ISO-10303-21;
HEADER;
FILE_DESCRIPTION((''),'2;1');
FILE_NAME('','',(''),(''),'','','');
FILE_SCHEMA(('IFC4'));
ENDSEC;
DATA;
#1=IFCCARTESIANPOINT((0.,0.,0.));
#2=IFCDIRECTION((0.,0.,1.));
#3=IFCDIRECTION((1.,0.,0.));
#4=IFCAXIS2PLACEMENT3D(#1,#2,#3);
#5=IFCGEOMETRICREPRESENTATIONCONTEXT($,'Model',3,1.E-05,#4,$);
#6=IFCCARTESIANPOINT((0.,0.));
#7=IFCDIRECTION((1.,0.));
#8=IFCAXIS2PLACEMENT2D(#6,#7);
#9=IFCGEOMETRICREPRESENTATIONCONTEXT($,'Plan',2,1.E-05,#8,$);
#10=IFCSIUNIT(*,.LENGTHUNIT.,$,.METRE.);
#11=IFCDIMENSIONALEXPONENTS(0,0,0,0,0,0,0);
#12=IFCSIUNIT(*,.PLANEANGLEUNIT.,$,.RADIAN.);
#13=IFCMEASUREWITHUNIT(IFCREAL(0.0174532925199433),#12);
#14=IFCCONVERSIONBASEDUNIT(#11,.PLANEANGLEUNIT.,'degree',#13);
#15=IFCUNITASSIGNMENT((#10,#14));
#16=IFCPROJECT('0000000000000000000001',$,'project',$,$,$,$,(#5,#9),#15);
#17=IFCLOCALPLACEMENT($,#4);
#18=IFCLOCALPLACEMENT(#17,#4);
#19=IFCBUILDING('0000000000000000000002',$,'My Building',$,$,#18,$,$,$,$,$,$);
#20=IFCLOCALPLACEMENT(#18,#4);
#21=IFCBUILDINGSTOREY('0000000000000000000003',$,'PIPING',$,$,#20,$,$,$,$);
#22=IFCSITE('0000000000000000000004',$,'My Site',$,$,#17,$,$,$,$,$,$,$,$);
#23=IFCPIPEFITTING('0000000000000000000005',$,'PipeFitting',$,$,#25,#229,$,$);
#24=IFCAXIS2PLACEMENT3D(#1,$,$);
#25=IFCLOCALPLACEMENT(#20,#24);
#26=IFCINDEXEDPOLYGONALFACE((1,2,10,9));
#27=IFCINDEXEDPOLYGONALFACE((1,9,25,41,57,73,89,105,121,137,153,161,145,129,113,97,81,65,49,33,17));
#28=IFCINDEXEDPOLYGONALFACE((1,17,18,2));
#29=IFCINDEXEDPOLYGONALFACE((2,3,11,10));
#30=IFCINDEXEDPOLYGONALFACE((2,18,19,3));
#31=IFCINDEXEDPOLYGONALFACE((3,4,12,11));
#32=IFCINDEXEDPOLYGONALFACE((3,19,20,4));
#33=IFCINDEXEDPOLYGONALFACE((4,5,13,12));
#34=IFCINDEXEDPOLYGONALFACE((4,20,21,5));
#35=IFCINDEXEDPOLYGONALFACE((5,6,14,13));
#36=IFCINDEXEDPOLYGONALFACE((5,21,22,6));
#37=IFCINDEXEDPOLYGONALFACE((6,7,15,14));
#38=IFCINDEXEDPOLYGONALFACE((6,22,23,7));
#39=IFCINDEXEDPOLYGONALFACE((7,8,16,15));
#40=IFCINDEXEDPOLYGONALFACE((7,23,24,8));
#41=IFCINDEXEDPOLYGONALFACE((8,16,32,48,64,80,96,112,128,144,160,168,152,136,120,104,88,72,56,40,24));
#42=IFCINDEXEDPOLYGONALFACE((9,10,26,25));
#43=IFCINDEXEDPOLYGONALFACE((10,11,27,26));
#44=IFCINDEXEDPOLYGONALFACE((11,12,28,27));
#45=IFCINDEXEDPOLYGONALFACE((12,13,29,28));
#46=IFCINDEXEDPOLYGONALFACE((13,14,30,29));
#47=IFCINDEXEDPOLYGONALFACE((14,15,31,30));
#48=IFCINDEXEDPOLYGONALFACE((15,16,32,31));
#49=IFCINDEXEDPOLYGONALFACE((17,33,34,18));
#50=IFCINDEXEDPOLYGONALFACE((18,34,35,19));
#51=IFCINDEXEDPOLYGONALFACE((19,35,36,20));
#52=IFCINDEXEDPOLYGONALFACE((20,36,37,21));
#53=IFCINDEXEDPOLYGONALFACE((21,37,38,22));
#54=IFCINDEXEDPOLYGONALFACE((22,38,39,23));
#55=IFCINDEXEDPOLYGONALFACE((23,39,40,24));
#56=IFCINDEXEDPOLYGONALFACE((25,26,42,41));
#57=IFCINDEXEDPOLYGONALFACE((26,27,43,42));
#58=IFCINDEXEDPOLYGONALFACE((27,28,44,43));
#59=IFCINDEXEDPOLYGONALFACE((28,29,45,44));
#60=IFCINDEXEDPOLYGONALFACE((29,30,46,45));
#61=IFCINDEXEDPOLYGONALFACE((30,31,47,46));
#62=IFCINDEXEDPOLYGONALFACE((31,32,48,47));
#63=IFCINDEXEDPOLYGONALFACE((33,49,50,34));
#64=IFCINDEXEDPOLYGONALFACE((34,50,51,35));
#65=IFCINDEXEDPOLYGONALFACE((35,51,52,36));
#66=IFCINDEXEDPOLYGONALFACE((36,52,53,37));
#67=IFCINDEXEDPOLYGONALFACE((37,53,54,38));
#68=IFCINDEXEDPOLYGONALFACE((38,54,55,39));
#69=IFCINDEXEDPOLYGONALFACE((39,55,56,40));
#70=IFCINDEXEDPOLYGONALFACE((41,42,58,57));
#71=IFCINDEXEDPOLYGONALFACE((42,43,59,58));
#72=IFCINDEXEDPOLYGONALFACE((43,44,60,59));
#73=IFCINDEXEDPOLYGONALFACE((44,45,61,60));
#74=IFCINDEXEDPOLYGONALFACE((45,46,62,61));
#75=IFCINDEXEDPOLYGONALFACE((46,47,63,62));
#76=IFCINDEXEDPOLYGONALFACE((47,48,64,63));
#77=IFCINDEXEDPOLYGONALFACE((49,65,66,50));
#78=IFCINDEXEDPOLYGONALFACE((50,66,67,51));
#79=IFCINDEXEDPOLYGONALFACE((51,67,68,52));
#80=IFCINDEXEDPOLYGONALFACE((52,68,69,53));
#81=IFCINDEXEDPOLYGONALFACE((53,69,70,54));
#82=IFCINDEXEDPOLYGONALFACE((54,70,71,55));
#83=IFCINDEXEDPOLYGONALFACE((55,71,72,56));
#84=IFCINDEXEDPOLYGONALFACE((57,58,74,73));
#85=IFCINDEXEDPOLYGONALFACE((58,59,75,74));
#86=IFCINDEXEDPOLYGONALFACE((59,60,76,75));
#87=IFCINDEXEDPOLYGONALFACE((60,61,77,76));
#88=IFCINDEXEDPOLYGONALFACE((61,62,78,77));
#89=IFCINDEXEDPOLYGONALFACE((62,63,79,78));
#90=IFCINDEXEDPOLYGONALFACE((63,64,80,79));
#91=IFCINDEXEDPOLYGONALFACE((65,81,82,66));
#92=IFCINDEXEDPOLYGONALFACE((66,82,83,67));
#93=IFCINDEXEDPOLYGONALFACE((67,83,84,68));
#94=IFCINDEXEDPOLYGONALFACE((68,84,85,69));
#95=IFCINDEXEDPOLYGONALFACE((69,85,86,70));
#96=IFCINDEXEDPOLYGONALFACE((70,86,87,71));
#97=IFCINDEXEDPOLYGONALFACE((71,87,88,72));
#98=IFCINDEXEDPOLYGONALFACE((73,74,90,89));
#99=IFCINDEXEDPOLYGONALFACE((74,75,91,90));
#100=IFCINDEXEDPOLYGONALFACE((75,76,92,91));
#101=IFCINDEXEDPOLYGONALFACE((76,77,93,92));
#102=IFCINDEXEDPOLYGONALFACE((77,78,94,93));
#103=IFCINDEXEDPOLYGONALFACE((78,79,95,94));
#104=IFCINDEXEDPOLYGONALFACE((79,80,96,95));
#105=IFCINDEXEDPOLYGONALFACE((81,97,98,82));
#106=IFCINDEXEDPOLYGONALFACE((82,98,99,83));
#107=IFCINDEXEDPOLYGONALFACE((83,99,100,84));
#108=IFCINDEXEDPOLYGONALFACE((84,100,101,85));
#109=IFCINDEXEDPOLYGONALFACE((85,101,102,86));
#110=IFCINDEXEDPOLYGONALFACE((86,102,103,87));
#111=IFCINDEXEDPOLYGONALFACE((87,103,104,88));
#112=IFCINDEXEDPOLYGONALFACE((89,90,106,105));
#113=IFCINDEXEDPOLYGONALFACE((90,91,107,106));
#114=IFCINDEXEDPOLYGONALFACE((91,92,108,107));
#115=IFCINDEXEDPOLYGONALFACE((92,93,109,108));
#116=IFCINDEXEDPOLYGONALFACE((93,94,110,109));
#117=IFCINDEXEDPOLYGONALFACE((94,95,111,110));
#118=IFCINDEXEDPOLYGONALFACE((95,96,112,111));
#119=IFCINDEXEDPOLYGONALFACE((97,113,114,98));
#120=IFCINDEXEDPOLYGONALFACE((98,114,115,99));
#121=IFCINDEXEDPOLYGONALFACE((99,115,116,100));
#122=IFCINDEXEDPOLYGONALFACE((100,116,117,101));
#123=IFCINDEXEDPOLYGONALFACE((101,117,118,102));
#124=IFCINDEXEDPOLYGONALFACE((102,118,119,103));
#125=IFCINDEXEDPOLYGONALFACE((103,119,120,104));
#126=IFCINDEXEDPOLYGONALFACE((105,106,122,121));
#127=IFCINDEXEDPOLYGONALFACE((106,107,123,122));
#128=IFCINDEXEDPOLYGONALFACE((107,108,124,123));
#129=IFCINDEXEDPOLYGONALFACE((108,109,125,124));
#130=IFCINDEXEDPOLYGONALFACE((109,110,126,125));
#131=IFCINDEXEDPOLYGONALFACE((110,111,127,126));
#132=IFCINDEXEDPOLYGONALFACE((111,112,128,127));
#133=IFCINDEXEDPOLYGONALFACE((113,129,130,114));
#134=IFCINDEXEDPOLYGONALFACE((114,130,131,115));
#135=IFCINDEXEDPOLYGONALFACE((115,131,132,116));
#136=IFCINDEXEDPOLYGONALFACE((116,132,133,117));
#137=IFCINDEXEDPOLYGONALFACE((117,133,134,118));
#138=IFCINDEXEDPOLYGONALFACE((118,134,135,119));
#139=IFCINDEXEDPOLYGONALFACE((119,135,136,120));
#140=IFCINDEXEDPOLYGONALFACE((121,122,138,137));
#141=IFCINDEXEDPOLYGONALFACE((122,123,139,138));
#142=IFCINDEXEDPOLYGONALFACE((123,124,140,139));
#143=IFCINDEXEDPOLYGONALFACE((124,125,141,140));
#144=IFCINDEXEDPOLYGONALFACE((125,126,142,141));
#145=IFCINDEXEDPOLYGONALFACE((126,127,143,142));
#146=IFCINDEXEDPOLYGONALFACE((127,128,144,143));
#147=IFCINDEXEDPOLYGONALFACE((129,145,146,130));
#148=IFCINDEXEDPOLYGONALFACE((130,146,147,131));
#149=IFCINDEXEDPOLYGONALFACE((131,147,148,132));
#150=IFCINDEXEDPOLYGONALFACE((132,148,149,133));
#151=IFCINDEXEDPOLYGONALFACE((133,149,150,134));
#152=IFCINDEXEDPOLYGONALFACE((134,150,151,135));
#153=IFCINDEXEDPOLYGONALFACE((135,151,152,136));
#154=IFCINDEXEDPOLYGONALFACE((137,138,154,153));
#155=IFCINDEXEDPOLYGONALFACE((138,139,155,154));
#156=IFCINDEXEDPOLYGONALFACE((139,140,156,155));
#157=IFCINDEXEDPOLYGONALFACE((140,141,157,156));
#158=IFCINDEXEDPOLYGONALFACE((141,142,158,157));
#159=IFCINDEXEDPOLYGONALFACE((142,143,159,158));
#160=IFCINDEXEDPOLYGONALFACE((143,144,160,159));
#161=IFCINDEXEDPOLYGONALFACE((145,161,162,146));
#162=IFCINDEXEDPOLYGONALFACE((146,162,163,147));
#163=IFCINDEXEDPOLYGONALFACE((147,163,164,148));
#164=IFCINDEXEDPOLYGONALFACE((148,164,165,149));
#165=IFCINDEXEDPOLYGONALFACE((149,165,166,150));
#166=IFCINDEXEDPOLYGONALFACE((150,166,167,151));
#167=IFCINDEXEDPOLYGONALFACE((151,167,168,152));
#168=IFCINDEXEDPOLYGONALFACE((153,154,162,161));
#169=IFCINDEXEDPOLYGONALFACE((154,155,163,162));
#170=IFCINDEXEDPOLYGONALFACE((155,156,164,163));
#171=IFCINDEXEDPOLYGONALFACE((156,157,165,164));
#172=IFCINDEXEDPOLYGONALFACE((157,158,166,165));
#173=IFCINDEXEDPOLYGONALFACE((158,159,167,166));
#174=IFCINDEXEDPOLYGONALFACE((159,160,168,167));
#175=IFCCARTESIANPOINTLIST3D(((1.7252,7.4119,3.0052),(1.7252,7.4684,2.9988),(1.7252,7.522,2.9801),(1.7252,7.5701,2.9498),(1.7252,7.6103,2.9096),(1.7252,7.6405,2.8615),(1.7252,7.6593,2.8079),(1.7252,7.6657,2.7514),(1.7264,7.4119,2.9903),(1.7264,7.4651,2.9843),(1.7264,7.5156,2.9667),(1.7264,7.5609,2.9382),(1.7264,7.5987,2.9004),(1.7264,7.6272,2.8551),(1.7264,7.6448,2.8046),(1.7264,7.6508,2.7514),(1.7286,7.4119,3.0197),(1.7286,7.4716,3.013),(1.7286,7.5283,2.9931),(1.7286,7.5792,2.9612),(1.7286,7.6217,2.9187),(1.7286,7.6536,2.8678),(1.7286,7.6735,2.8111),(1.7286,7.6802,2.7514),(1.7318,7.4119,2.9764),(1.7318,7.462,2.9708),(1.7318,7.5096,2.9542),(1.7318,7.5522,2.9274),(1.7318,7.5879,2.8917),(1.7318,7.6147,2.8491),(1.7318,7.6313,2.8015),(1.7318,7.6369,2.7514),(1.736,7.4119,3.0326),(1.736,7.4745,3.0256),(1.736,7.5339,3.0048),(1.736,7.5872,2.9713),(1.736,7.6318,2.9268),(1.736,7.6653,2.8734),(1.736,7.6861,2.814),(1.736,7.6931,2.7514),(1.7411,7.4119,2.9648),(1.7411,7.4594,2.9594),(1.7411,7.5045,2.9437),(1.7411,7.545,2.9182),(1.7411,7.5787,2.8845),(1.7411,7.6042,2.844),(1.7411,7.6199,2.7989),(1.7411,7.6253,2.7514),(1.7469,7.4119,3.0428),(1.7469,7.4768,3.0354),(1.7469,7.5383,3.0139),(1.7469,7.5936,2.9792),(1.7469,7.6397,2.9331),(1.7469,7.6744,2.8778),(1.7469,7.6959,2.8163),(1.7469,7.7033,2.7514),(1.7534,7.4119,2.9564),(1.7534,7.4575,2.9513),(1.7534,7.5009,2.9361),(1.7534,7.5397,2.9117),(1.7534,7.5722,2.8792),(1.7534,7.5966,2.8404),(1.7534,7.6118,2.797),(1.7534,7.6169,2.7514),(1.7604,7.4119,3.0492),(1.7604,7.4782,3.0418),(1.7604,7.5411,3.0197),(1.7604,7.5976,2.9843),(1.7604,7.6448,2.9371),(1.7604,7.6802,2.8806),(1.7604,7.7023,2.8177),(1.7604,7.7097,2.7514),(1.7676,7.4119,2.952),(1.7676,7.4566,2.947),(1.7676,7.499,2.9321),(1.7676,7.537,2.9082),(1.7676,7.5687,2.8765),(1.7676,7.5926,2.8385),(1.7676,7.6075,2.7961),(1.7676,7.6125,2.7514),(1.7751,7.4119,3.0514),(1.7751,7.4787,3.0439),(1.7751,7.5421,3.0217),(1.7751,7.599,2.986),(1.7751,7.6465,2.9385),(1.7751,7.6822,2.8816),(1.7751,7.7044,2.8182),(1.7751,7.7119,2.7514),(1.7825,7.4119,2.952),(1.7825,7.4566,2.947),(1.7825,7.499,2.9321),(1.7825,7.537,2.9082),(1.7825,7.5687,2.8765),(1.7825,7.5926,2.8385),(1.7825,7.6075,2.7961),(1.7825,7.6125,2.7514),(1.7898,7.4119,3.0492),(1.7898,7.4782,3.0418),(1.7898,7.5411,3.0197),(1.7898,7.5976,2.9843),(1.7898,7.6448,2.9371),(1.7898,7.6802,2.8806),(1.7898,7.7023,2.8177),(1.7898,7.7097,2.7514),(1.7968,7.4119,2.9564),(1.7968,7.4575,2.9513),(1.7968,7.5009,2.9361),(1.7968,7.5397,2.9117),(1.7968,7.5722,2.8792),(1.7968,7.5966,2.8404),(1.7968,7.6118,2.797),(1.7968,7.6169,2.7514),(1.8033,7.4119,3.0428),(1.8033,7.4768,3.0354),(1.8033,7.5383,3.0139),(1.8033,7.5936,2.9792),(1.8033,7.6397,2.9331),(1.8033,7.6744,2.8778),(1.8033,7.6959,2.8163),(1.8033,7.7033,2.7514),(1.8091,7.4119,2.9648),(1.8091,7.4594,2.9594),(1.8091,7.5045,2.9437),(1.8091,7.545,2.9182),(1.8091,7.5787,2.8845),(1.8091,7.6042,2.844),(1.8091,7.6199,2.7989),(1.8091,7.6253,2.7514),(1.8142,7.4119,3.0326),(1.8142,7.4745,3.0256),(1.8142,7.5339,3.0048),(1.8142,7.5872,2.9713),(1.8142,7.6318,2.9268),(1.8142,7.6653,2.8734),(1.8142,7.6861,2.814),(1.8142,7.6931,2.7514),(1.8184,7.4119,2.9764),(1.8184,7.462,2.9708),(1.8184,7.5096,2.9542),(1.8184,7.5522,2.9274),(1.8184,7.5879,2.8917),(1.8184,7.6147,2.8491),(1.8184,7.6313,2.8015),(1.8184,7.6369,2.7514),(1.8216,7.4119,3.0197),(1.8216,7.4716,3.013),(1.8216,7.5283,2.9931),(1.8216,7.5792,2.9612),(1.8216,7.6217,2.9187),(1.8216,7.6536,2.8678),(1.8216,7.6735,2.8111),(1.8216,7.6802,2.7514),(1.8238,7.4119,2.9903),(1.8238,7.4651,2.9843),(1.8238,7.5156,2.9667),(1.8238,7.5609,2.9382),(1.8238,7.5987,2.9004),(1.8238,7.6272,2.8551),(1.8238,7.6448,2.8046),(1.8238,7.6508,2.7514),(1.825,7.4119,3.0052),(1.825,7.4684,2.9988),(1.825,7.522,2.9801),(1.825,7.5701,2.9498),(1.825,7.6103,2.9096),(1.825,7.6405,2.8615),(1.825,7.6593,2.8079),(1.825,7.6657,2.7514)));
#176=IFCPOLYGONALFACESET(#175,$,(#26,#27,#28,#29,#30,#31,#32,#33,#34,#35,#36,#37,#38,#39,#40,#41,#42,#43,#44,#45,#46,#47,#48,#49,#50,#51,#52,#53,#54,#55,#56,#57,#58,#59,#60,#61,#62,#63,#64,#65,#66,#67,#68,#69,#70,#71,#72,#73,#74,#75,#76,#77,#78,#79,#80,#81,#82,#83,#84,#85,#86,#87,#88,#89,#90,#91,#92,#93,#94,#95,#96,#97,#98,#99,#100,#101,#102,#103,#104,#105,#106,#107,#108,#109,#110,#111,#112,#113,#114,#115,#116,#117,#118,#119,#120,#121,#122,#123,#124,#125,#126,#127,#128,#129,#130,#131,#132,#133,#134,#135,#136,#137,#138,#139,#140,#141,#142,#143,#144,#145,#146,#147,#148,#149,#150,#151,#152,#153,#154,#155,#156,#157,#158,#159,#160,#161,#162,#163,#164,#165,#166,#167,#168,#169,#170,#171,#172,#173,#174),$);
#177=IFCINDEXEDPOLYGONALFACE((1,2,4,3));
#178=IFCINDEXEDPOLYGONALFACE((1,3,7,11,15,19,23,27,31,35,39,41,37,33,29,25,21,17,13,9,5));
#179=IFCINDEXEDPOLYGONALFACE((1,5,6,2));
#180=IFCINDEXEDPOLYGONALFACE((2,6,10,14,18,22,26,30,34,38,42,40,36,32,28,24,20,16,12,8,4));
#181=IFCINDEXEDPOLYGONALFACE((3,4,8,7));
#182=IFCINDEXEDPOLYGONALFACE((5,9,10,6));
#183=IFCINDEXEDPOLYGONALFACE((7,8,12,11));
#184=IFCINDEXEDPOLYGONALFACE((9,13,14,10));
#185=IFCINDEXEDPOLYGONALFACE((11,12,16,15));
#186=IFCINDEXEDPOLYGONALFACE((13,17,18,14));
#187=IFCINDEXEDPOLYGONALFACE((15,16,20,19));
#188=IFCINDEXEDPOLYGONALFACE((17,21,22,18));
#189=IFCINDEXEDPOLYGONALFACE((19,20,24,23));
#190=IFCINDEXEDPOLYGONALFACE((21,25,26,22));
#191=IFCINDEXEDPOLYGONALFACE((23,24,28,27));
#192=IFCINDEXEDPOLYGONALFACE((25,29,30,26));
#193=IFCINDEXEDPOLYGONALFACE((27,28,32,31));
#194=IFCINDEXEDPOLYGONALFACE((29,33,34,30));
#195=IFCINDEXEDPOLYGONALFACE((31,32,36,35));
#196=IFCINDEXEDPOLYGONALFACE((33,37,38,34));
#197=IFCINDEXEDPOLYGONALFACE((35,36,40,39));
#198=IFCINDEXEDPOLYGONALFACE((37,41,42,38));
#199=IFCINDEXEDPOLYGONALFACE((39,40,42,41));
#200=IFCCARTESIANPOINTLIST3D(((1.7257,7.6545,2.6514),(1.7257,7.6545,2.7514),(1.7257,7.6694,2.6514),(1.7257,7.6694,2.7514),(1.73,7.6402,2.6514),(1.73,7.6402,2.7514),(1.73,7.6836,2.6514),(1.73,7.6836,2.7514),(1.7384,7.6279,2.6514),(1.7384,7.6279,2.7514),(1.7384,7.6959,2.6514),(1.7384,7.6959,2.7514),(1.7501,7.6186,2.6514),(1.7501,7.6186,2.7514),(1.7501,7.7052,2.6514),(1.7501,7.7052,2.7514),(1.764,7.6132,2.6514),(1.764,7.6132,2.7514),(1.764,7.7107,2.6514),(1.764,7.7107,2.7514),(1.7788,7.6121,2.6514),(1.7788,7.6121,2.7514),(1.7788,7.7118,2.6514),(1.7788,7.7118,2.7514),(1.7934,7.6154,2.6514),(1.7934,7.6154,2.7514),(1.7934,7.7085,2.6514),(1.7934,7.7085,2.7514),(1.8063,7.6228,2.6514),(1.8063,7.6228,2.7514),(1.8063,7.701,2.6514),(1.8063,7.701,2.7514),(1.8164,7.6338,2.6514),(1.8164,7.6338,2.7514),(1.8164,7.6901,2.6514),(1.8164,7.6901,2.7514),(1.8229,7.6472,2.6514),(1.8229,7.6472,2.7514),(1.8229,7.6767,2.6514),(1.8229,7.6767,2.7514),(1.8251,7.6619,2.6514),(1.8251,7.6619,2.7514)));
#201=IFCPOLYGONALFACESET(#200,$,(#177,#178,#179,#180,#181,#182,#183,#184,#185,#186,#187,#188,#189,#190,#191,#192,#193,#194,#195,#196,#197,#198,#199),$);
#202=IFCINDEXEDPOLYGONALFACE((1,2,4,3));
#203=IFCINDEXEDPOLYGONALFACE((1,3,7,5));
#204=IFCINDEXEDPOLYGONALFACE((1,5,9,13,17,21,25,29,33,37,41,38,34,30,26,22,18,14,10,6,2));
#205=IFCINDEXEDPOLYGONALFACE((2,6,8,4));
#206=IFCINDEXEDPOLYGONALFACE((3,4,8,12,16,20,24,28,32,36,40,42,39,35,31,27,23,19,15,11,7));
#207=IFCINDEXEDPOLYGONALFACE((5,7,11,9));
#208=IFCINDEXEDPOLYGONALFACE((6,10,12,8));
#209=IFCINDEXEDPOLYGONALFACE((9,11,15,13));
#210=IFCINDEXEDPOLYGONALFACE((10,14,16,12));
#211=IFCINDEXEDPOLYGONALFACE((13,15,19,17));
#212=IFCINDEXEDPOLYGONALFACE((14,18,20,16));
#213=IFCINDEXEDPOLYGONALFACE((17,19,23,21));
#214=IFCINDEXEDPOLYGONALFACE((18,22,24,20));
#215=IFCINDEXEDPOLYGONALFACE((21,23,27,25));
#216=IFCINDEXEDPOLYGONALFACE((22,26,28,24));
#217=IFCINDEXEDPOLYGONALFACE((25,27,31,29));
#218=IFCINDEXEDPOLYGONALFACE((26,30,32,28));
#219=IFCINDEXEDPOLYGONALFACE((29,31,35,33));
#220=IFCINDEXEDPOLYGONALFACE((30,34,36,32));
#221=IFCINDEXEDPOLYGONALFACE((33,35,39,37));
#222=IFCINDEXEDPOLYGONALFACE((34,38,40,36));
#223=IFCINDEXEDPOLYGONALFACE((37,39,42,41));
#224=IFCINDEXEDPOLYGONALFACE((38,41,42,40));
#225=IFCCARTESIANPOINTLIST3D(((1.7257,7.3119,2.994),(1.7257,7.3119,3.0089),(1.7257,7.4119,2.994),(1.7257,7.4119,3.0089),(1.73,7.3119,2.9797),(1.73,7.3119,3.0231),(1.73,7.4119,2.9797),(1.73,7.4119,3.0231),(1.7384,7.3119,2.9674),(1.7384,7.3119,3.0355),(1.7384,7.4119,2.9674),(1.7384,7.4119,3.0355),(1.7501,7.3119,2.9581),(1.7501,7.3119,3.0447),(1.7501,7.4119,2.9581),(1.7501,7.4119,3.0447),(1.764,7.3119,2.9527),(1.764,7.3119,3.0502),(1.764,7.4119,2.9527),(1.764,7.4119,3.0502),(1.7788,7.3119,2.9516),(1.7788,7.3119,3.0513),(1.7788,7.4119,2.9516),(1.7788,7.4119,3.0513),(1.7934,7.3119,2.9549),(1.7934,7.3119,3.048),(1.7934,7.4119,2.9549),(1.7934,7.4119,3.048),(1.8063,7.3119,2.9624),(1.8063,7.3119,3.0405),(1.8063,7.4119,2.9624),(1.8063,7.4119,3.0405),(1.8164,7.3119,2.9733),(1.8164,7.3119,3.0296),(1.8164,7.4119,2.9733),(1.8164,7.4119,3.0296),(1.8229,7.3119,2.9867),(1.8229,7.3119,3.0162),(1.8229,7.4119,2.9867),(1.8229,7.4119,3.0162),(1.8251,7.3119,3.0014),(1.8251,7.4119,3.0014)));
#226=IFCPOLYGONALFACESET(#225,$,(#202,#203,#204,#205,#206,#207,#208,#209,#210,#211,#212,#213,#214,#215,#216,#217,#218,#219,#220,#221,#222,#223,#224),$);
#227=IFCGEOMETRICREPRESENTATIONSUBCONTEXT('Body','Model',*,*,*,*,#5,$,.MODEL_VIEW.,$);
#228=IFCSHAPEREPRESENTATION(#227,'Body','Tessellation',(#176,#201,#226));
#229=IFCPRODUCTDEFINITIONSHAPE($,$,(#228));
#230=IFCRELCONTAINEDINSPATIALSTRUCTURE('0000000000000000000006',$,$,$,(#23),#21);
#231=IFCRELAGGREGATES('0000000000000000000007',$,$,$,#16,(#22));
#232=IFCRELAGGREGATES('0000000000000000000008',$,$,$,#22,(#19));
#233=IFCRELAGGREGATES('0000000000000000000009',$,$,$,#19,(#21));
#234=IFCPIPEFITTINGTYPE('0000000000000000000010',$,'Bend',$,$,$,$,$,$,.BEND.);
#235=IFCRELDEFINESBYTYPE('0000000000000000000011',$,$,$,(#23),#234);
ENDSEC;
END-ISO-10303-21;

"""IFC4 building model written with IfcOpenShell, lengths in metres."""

from ifc_helpers import new_model, entity, si_unit, converted_unit, frame, origin_with_axes, origin_2d_with_axis, place, context, subcontext, project, spatial, circle, extrude, source, transform, mapped, type_object, type_shapes, element, save


model = new_model("IFC4")

# Units and contexts
model_context = context("Model", 3, precision=1e-05, world=origin_with_axes())
plan_context = context("Plan", 2, precision=1e-05, world=origin_2d_with_axis())
body_context = subcontext(model_context, "Body", "Model", "MODEL_VIEW")
ifc_project = project(units=[si_unit("LENGTHUNIT", "METRE"), converted_unit("PLANEANGLEUNIT", "degree", entity("IfcReal", 0.0174532925199433), si_unit("PLANEANGLEUNIT", "RADIAN"), dimensions=[0, 0, 0, 0, 0, 0, 0])], contexts=[model_context, plan_context])

# Site, building, storey
site_placement = place(None, origin_with_axes())
site = spatial("IfcSite", under=ifc_project, at=site_placement, Name="My Site")
building_placement = place(site_placement, origin_with_axes())
building = spatial("IfcBuilding", under=site, at=building_placement, Name="My Building")
storey_placement = place(building_placement, origin_with_axes())
storey = spatial("IfcBuildingStorey", under=building, at=storey_placement, Name="PIPING")

# Pipe fitting
pipe_fitting_type_1 = type_object("IfcPipeFittingType", Name="Bend", PredefinedType="BEND")
shared_shape = source(origin_with_axes(), body_context, "Body", "SolidModel", [
    entity("IfcSweptDiskSolid", entity("IfcIndexedPolyCurve", entity("IfcCartesianPointList3D", [[0.0, 0.0, -0.1], [0.0, 0.0732, -0.2768], [0.0, 0.25, -0.35]]), [entity("IfcArcIndex", [1, 2, 3])]), 0.05),
    extrude(circle(Radius=0.05), origin_with_axes(), (0.0, 0.0, -1.0), 0.1),
    extrude(circle(Radius=0.05), frame((0.0, 0.25, -0.35), z_axis=(0.0, 1.0, 0.0), x_axis=(1.0, 0.0, 0.0)), (0.0, 0.0, 1.0), 0.1),
])
type_shapes(pipe_fitting_type_1, [shared_shape])
for number, where, z_axis, x_axis, name in (
    (1, (1.7751, 7.6619, 2.6514), (0.0, 0.0, -1.0), (1.0, 0.0, 0.0), "PipeFitting"),
):
    element("IfcPipeFitting", number, at=place(storey_placement, frame(where, z_axis=z_axis, x_axis=x_axis)), inside=storey, type_object=pipe_fitting_type_1, Name=name, context=body_context, shape_type="MappedRepresentation", body=[
        mapped(shared_shape, transform((0.0, 0.0, 0.0), x_axis=(1.0, 0.0, 0.0), y_axis=(0.0, 1.0, 0.0), z_axis=(0.0, 0.0, 1.0), scale=1.0)),
    ])

save(model, "model.ifc")
